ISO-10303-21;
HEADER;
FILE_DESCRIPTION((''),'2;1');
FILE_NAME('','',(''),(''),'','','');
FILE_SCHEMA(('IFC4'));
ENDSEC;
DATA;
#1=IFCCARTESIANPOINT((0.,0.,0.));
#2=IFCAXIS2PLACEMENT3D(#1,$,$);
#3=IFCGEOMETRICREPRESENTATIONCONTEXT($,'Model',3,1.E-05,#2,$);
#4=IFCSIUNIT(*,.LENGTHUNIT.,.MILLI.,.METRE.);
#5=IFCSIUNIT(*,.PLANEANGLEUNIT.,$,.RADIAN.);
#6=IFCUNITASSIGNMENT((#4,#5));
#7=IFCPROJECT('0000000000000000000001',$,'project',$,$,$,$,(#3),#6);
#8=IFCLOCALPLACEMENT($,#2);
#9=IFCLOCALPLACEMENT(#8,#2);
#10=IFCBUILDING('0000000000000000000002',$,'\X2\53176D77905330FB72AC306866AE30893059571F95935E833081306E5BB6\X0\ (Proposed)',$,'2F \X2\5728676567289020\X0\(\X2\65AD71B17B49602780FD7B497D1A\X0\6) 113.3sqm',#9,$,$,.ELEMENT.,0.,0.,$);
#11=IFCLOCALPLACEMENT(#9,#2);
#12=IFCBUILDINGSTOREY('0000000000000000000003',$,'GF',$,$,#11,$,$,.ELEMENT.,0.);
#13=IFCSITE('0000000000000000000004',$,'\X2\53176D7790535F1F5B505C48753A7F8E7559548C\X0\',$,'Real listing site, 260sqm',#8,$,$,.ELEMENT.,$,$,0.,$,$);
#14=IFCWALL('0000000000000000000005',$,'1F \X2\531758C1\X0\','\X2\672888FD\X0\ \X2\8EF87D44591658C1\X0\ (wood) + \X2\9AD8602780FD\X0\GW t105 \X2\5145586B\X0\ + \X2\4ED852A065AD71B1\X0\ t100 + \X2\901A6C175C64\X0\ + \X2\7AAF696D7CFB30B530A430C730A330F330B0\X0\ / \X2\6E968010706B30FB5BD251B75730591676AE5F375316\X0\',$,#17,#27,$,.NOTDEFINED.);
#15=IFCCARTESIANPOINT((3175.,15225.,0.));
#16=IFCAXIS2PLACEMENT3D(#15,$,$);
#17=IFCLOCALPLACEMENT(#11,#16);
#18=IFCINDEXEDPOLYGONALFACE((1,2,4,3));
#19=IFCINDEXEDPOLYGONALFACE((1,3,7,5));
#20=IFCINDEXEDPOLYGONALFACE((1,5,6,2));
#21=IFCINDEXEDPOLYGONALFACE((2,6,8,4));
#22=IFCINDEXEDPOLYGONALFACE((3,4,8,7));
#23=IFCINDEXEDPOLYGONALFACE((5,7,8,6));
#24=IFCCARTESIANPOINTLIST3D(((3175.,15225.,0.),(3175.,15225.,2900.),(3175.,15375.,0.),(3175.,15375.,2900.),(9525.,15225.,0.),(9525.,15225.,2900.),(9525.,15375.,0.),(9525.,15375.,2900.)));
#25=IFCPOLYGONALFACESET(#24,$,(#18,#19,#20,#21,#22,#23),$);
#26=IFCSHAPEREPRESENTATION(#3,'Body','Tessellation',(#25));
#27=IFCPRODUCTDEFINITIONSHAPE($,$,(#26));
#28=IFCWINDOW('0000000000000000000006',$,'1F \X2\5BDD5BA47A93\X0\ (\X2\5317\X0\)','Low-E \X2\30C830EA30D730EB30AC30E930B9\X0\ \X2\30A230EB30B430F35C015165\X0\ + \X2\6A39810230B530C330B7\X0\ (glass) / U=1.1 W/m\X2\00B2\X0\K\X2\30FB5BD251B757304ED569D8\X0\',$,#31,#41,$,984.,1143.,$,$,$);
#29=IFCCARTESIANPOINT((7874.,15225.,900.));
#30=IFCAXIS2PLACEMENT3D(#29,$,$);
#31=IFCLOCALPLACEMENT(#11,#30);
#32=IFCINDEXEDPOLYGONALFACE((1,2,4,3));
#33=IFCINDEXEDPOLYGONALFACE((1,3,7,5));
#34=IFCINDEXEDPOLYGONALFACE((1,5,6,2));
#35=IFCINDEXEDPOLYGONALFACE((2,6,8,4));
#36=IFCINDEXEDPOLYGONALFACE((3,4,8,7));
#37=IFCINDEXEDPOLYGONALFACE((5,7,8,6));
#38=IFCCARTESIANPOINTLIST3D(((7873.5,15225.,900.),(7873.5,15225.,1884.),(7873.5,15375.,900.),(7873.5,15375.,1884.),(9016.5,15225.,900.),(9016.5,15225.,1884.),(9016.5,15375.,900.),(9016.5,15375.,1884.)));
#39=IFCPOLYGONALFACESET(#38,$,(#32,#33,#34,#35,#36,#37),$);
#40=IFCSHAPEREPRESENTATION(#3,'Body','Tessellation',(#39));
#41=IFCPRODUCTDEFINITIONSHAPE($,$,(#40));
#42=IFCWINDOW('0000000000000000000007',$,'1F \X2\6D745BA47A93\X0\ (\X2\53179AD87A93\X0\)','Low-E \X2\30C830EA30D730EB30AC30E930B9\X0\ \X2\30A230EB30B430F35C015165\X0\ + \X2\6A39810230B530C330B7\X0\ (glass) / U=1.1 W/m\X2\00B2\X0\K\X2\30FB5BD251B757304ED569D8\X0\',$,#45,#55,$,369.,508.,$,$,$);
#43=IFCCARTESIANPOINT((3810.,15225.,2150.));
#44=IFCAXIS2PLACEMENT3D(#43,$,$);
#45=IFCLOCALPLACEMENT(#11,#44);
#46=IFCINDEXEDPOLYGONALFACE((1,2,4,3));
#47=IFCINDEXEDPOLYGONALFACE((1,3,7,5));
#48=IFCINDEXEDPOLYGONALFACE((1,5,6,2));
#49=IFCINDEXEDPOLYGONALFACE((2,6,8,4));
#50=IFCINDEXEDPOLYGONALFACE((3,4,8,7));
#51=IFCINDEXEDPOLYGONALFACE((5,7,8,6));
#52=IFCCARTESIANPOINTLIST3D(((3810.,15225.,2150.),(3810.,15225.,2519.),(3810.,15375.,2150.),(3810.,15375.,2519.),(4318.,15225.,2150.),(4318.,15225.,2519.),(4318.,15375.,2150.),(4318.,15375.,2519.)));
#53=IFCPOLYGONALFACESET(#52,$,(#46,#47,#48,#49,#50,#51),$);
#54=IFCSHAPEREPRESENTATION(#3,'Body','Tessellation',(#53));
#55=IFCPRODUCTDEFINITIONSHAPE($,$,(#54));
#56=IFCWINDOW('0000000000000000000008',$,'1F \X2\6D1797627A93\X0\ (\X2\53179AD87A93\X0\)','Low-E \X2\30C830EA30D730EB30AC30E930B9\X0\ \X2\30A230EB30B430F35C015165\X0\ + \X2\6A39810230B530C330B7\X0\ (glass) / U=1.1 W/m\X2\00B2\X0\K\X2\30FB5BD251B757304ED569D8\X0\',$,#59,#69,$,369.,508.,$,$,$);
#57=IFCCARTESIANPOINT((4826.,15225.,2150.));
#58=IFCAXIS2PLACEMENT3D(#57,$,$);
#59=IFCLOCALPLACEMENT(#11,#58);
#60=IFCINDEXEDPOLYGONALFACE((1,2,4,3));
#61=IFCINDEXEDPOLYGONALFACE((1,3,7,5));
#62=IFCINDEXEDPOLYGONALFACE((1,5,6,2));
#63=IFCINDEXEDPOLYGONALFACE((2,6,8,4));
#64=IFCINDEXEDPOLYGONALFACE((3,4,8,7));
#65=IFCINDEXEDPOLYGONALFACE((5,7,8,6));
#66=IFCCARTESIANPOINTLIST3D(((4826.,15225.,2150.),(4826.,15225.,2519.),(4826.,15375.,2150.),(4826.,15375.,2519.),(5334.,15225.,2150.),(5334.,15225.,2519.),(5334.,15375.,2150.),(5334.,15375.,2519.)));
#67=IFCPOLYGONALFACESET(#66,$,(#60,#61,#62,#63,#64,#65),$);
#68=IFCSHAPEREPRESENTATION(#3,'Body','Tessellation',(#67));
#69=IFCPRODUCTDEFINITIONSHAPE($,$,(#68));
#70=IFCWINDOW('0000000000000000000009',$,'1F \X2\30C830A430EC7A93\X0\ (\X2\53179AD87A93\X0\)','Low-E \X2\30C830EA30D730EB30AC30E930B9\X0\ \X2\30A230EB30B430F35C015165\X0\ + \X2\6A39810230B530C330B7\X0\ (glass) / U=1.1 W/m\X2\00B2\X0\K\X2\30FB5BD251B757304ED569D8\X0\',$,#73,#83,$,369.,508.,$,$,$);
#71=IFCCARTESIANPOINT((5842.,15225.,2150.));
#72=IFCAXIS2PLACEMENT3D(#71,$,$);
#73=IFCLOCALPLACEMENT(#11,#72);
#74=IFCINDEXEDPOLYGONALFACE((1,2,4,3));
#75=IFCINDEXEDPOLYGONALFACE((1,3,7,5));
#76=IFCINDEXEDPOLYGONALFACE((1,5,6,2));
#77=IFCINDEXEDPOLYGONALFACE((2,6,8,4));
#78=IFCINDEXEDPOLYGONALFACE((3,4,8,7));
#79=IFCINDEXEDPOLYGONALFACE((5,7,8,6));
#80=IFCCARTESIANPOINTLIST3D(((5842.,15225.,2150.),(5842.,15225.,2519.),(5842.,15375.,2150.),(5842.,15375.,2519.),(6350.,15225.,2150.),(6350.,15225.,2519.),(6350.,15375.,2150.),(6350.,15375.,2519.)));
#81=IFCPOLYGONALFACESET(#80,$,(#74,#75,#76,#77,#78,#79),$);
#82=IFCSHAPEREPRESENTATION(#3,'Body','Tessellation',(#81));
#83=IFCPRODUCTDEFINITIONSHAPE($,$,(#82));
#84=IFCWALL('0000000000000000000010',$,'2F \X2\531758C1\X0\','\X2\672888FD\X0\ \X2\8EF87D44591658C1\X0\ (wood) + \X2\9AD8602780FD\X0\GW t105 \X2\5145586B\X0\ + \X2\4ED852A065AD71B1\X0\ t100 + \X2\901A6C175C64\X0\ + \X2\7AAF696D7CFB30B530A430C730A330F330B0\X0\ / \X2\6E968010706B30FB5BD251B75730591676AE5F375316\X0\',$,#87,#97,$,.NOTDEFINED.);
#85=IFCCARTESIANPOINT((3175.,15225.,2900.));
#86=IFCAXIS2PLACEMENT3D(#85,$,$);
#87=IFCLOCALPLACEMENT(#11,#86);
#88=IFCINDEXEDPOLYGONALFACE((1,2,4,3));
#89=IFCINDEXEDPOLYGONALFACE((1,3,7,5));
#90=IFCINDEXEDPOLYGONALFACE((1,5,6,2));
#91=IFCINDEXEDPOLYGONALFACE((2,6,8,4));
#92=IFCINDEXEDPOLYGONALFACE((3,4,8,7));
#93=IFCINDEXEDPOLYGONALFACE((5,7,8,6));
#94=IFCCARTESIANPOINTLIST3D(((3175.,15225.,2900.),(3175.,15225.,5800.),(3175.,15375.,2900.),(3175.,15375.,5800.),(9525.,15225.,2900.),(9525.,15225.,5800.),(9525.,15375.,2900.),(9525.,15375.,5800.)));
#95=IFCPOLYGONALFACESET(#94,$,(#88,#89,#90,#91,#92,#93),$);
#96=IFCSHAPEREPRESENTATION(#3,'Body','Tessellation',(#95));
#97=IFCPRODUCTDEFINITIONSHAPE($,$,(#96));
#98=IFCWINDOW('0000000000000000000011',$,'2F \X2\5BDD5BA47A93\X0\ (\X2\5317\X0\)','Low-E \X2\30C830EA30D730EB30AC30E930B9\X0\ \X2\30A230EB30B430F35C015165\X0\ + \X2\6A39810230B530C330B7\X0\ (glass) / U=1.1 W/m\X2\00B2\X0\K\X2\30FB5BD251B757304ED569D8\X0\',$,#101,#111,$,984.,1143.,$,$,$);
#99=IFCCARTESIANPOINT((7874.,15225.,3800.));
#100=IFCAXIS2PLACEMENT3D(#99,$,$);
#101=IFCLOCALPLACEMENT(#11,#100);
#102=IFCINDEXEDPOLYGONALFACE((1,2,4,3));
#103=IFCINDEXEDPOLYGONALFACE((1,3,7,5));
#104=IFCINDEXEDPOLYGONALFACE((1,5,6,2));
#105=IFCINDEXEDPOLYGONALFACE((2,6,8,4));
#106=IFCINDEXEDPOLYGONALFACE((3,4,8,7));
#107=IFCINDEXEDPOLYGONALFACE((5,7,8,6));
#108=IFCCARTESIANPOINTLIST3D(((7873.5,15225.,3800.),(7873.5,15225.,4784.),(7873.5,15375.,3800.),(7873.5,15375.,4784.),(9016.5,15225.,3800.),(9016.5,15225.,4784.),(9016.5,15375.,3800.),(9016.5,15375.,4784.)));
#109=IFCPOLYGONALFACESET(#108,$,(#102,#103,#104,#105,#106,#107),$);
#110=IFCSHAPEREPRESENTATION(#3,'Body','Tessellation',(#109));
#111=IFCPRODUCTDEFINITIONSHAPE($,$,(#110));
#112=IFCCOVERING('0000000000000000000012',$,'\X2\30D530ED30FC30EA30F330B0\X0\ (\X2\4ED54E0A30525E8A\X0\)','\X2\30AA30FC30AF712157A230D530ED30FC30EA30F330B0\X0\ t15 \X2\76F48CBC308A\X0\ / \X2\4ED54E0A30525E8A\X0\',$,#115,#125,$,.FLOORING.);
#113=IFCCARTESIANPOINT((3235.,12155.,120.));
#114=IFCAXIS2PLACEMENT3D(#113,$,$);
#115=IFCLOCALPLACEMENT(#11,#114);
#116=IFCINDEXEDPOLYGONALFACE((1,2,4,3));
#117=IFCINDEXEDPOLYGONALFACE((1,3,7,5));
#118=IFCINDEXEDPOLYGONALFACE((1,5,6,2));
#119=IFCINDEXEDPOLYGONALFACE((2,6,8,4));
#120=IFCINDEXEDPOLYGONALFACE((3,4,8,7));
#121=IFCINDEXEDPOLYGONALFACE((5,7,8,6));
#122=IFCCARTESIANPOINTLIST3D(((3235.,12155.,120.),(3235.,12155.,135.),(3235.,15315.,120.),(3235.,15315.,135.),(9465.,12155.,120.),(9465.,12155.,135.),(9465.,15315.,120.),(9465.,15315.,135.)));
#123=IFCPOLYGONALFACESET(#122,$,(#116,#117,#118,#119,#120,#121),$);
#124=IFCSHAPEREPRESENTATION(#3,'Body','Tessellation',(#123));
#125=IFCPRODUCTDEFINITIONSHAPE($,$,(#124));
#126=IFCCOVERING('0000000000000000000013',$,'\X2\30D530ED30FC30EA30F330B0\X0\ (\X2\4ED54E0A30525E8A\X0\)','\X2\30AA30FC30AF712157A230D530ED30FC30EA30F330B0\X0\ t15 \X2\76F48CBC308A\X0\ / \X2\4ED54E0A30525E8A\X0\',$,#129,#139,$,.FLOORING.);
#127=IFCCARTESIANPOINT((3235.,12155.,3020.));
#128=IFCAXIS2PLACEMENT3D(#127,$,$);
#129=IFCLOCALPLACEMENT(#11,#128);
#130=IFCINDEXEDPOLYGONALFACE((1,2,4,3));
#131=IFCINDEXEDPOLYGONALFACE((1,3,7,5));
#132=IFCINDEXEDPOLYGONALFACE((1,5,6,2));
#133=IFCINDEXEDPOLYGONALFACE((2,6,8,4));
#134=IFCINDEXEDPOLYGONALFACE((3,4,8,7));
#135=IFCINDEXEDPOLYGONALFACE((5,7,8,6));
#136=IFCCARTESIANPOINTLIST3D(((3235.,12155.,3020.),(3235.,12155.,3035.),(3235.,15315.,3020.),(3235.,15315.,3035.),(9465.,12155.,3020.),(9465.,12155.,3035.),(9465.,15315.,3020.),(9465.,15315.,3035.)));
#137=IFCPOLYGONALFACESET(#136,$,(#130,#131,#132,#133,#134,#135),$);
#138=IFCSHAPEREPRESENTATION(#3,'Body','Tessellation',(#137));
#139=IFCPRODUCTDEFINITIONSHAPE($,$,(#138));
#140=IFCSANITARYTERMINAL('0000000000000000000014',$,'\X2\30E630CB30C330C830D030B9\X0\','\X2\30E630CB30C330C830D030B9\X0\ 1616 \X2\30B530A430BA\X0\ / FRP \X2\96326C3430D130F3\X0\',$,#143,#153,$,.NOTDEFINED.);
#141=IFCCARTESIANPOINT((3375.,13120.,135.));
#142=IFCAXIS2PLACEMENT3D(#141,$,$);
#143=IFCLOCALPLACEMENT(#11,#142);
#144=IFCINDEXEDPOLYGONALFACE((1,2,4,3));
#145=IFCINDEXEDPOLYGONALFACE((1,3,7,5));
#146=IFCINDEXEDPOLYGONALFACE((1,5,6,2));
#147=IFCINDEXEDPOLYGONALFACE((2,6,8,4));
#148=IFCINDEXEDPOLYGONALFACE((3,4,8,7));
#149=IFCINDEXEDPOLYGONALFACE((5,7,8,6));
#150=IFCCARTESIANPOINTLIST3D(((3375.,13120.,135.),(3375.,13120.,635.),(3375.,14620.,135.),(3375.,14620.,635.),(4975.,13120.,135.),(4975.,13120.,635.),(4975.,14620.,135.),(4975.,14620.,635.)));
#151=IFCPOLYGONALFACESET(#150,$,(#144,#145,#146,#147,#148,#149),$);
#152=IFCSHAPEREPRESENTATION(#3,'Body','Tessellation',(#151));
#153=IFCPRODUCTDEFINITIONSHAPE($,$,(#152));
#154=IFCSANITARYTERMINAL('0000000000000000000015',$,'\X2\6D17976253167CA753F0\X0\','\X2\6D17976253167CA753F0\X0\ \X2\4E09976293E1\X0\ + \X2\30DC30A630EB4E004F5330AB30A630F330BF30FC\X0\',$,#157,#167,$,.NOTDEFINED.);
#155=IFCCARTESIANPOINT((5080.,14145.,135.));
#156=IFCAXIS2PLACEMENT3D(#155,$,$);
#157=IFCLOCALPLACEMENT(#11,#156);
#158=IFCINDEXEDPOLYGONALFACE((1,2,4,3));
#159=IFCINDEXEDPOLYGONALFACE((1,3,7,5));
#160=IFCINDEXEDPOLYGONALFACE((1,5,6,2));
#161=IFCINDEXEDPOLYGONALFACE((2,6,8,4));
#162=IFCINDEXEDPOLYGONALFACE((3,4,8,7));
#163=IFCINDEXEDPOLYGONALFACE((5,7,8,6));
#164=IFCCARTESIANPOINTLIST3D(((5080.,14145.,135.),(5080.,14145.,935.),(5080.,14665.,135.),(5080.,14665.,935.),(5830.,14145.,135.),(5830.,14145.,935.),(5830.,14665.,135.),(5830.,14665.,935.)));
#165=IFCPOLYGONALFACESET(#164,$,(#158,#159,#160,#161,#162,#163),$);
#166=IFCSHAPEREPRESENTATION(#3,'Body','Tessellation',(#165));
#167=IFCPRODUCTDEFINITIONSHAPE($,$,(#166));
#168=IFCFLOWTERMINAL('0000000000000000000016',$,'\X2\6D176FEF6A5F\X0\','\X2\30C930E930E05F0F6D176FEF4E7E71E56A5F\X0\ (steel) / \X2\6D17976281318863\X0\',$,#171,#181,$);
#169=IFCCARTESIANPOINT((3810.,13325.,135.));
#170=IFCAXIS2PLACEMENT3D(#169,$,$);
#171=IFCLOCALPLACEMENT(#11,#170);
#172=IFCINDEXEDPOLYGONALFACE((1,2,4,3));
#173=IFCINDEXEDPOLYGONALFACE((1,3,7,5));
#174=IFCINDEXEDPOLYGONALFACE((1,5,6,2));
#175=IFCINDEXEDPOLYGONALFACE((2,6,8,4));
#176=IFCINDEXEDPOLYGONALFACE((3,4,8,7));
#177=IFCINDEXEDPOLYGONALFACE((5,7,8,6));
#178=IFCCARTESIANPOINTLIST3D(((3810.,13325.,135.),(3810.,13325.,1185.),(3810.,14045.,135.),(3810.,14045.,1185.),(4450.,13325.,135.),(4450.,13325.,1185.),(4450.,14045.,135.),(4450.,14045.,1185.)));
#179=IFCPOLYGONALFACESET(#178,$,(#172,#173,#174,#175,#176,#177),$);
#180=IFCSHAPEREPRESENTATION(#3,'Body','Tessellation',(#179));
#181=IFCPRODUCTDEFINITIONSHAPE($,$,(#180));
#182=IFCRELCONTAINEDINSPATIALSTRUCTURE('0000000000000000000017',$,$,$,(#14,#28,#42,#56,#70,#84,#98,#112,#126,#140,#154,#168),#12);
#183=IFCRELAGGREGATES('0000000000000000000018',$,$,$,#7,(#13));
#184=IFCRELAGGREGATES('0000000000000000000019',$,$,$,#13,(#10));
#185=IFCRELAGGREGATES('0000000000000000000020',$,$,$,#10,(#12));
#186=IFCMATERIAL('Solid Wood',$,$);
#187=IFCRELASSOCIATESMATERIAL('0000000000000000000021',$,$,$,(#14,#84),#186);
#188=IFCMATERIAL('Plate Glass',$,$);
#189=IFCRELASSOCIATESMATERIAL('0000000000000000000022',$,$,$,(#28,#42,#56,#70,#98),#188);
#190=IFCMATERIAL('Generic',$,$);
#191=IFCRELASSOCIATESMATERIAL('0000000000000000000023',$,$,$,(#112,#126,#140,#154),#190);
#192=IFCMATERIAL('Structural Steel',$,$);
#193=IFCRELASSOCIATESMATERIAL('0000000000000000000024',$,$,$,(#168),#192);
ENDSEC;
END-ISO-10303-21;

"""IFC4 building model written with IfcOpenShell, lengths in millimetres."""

from ifc_helpers import new_model, si_unit, frame, frame_2d, origin, place, context, project, spatial, rectangle, extrude, material, element, fill, save


model = new_model("IFC4")

# Units and contexts
model_context = context("Model", 3, precision=1e-05, world=origin())
ifc_project = project(units=[si_unit("LENGTHUNIT", "METRE", prefix="MILLI"), si_unit("PLANEANGLEUNIT", "RADIAN")], contexts=[model_context])

# Site, building, storey
site_placement = place(None, origin())
site = spatial("IfcSite", under=ifc_project, at=site_placement, Name="北海道弟子屈町美留和", ObjectType="Real listing site, 260sqm", CompositionType="ELEMENT", RefElevation=0.0)
building_placement = place(site_placement, origin())
building = spatial("IfcBuilding", under=site, at=building_placement, Name="北海道・犬と暮らす土間広めの家 (Proposed)", ObjectType="2F 在来木造(断熱等性能等級6) 113.3sqm", CompositionType="ELEMENT", ElevationOfRefHeight=0.0, ElevationOfTerrain=0.0)
storey_placement = place(building_placement, origin())
storey = spatial("IfcBuildingStorey", under=building, at=storey_placement, Name="GF", CompositionType="ELEMENT", Elevation=0.0)

# Shared definitions
ifc_material_1 = material(Name="Solid Wood")

# Wall, openings, windows
wall_1_placement = place(storey_placement, frame((3175.0, 15225.0, 0.0)))
wall_1 = element("IfcWall", 1, at=wall_1_placement, inside=storey, material=ifc_material_1, Name="1F 北壁", Description="木製 軸組外壁 (wood) + 高性能GW t105 充填 + 付加断熱 t100 + 通気層 + 窯業系サイディング / 準耐火・寒冷地外皮強化", PredefinedType="NOTDEFINED", context=model_context, shape_type="SweptSolid", body=[
    extrude(rectangle(XDim=6350.0, YDim=150.0, at=frame_2d((3175.0, 75.0))), frame((3175.0, 15225.0, 0.0)), (0.0, 0.0, 1.0), 2900.0),
])
opening_1_placement = place(storey_placement, frame((7874.0, 15225.0, 900.0)))
opening_1 = element("IfcOpeningElement", 2, at=opening_1_placement, cuts=wall_1, PredefinedType="NOTDEFINED", context=model_context, shape_type="SweptSolid", body=[
    extrude(rectangle(XDim=1143.0, YDim=150.0, at=frame_2d((571.0, 75.0))), frame((7874.0, 15225.0, 900.0)), (0.0, 0.0, 1.0), 984.0),
])
opening_2_placement = place(storey_placement, frame((3810.0, 15225.0, 2150.0)))
opening_2 = element("IfcOpeningElement", 3, at=opening_2_placement, cuts=wall_1, PredefinedType="NOTDEFINED", context=model_context, shape_type="SweptSolid", body=[
    extrude(rectangle(XDim=508.0, YDim=150.0, at=frame_2d((254.0, 75.0))), frame((3810.0, 15225.0, 2150.0)), (0.0, 0.0, 1.0), 369.0),
])
opening_3_placement = place(storey_placement, frame((4826.0, 15225.0, 2150.0)))
opening_3 = element("IfcOpeningElement", 4, at=opening_3_placement, cuts=wall_1, PredefinedType="NOTDEFINED", context=model_context, shape_type="SweptSolid", body=[
    extrude(rectangle(XDim=508.0, YDim=150.0, at=frame_2d((254.0, 75.0))), frame((4826.0, 15225.0, 2150.0)), (0.0, 0.0, 1.0), 369.0),
])
opening_4_placement = place(storey_placement, frame((5842.0, 15225.0, 2150.0)))
opening_4 = element("IfcOpeningElement", 5, at=opening_4_placement, cuts=wall_1, PredefinedType="NOTDEFINED", context=model_context, shape_type="SweptSolid", body=[
    extrude(rectangle(XDim=508.0, YDim=150.0, at=frame_2d((254.0, 75.0))), frame((5842.0, 15225.0, 2150.0)), (0.0, 0.0, 1.0), 369.0),
])
ifc_material_2 = material(Name="Plate Glass")
window_1_placement = place(storey_placement, frame((7874.0, 15225.0, 900.0)))
window_1 = element("IfcWindow", 6, at=window_1_placement, inside=storey, material=ifc_material_2, Name="1F 寝室窓 (北)", Description="Low-E トリプルガラス アルゴン封入 + 樹脂サッシ (glass) / U=1.1 W/m²K・寒冷地仕様", OverallHeight=984.0, OverallWidth=1143.0, context=model_context, shape_type="SweptSolid", body=[
    extrude(rectangle(XDim=1143.0, YDim=150.0, at=frame_2d((571.0, 75.0))), frame((7874.0, 15225.0, 900.0)), (0.0, 0.0, 1.0), 984.0),
])
fill(opening_1, window_1)
window_2_placement = place(storey_placement, frame((3810.0, 15225.0, 2150.0)))
window_2 = element("IfcWindow", 7, at=window_2_placement, inside=storey, material=ifc_material_2, Name="1F 浴室窓 (北高窓)", Description="Low-E トリプルガラス アルゴン封入 + 樹脂サッシ (glass) / U=1.1 W/m²K・寒冷地仕様", OverallHeight=369.0, OverallWidth=508.0, context=model_context, shape_type="SweptSolid", body=[
    extrude(rectangle(XDim=508.0, YDim=150.0, at=frame_2d((254.0, 75.0))), frame((3810.0, 15225.0, 2150.0)), (0.0, 0.0, 1.0), 369.0),
])
fill(opening_2, window_2)
window_3_placement = place(storey_placement, frame((4826.0, 15225.0, 2150.0)))
window_3 = element("IfcWindow", 8, at=window_3_placement, inside=storey, material=ifc_material_2, Name="1F 洗面窓 (北高窓)", Description="Low-E トリプルガラス アルゴン封入 + 樹脂サッシ (glass) / U=1.1 W/m²K・寒冷地仕様", OverallHeight=369.0, OverallWidth=508.0, context=model_context, shape_type="SweptSolid", body=[
    extrude(rectangle(XDim=508.0, YDim=150.0, at=frame_2d((254.0, 75.0))), frame((4826.0, 15225.0, 2150.0)), (0.0, 0.0, 1.0), 369.0),
])
fill(opening_3, window_3)
window_4_placement = place(storey_placement, frame((5842.0, 15225.0, 2150.0)))
window_4 = element("IfcWindow", 9, at=window_4_placement, inside=storey, material=ifc_material_2, Name="1F トイレ窓 (北高窓)", Description="Low-E トリプルガラス アルゴン封入 + 樹脂サッシ (glass) / U=1.1 W/m²K・寒冷地仕様", OverallHeight=369.0, OverallWidth=508.0, context=model_context, shape_type="SweptSolid", body=[
    extrude(rectangle(XDim=508.0, YDim=150.0, at=frame_2d((254.0, 75.0))), frame((5842.0, 15225.0, 2150.0)), (0.0, 0.0, 1.0), 369.0),
])
fill(opening_4, window_4)

# Wall, opening, window
wall_2_placement = place(storey_placement, frame((3175.0, 15225.0, 2900.0)))
wall_2 = element("IfcWall", 10, at=wall_2_placement, inside=storey, material=ifc_material_1, Name="2F 北壁", Description="木製 軸組外壁 (wood) + 高性能GW t105 充填 + 付加断熱 t100 + 通気層 + 窯業系サイディング / 準耐火・寒冷地外皮強化", PredefinedType="NOTDEFINED", context=model_context, shape_type="SweptSolid", body=[
    extrude(rectangle(XDim=6350.0, YDim=150.0, at=frame_2d((3175.0, 75.0))), frame((3175.0, 15225.0, 2900.0)), (0.0, 0.0, 1.0), 2900.0),
])
opening_5_placement = place(storey_placement, frame((7874.0, 15225.0, 3800.0)))
opening_5 = element("IfcOpeningElement", 11, at=opening_5_placement, cuts=wall_2, PredefinedType="NOTDEFINED", context=model_context, shape_type="SweptSolid", body=[
    extrude(rectangle(XDim=1143.0, YDim=150.0, at=frame_2d((571.0, 75.0))), frame((7874.0, 15225.0, 3800.0)), (0.0, 0.0, 1.0), 984.0),
])
window_5_placement = place(storey_placement, frame((7874.0, 15225.0, 3800.0)))
window_5 = element("IfcWindow", 12, at=window_5_placement, inside=storey, material=ifc_material_2, Name="2F 寝室窓 (北)", Description="Low-E トリプルガラス アルゴン封入 + 樹脂サッシ (glass) / U=1.1 W/m²K・寒冷地仕様", OverallHeight=984.0, OverallWidth=1143.0, context=model_context, shape_type="SweptSolid", body=[
    extrude(rectangle(XDim=1143.0, YDim=150.0, at=frame_2d((571.0, 75.0))), frame((7874.0, 15225.0, 3800.0)), (0.0, 0.0, 1.0), 984.0),
])
fill(opening_5, window_5)

# Coverings
ifc_material_3 = material(Name="Generic")
covering_1_placement = place(storey_placement, frame((3235.0, 12155.0, 120.0)))
element("IfcCovering", 13, at=covering_1_placement, inside=storey, material=ifc_material_3, Name="フローリング (仕上げ床)", Description="オーク無垢フローリング t15 直貼り / 仕上げ床", PredefinedType="FLOORING", context=model_context, shape_type="SweptSolid", body=[
    extrude(rectangle(XDim=6230.0, YDim=3160.0, at=frame_2d((3115.0, 1580.0))), frame((3235.0, 12155.0, 120.0)), (0.0, 0.0, 1.0), 15.0),
])
covering_2_placement = place(storey_placement, frame((3235.0, 12155.0, 3020.0)))
element("IfcCovering", 14, at=covering_2_placement, inside=storey, material=ifc_material_3, Name="フローリング (仕上げ床)", Description="オーク無垢フローリング t15 直貼り / 仕上げ床", PredefinedType="FLOORING", context=model_context, shape_type="SweptSolid", body=[
    extrude(rectangle(XDim=6230.0, YDim=3160.0, at=frame_2d((3115.0, 1580.0))), frame((3235.0, 12155.0, 3020.0)), (0.0, 0.0, 1.0), 15.0),
])

# Sanitary terminals
sanitary_terminal_1_placement = place(storey_placement, frame((3375.0, 13120.0, 135.0)))
element("IfcSanitaryTerminal", 15, at=sanitary_terminal_1_placement, inside=storey, material=ifc_material_3, Name="ユニットバス", Description="ユニットバス 1616 サイズ / FRP 防水パン", PredefinedType="NOTDEFINED", context=model_context, shape_type="SweptSolid", body=[
    extrude(rectangle(XDim=1600.0, YDim=1500.0, at=frame_2d((800.0, 750.0))), frame((3375.0, 13120.0, 135.0)), (0.0, 0.0, 1.0), 500.0),
])
sanitary_terminal_2_placement = place(storey_placement, frame((5080.0, 14145.0, 135.0)))
element("IfcSanitaryTerminal", 16, at=sanitary_terminal_2_placement, inside=storey, material=ifc_material_3, Name="洗面化粧台", Description="洗面化粧台 三面鏡 + ボウル一体カウンター", PredefinedType="NOTDEFINED", context=model_context, shape_type="SweptSolid", body=[
    extrude(rectangle(XDim=750.0, YDim=520.0, at=frame_2d((375.0, 260.0))), frame((5080.0, 14145.0, 135.0)), (0.0, 0.0, 1.0), 800.0),
])

# Flow terminal
ifc_material_4 = material(Name="Structural Steel")
flow_terminal_placement = place(storey_placement, frame((3810.0, 13325.0, 135.0)))
element("IfcFlowTerminal", 17, at=flow_terminal_placement, inside=storey, material=ifc_material_4, Name="洗濯機", Description="ドラム式洗濯乾燥機 (steel) / 洗面脱衣", context=model_context, shape_type="SweptSolid", body=[
    extrude(rectangle(XDim=640.0, YDim=720.0, at=frame_2d((320.0, 360.0))), frame((3810.0, 13325.0, 135.0)), (0.0, 0.0, 1.0), 1050.0),
])

save(model, "model.ifc")
